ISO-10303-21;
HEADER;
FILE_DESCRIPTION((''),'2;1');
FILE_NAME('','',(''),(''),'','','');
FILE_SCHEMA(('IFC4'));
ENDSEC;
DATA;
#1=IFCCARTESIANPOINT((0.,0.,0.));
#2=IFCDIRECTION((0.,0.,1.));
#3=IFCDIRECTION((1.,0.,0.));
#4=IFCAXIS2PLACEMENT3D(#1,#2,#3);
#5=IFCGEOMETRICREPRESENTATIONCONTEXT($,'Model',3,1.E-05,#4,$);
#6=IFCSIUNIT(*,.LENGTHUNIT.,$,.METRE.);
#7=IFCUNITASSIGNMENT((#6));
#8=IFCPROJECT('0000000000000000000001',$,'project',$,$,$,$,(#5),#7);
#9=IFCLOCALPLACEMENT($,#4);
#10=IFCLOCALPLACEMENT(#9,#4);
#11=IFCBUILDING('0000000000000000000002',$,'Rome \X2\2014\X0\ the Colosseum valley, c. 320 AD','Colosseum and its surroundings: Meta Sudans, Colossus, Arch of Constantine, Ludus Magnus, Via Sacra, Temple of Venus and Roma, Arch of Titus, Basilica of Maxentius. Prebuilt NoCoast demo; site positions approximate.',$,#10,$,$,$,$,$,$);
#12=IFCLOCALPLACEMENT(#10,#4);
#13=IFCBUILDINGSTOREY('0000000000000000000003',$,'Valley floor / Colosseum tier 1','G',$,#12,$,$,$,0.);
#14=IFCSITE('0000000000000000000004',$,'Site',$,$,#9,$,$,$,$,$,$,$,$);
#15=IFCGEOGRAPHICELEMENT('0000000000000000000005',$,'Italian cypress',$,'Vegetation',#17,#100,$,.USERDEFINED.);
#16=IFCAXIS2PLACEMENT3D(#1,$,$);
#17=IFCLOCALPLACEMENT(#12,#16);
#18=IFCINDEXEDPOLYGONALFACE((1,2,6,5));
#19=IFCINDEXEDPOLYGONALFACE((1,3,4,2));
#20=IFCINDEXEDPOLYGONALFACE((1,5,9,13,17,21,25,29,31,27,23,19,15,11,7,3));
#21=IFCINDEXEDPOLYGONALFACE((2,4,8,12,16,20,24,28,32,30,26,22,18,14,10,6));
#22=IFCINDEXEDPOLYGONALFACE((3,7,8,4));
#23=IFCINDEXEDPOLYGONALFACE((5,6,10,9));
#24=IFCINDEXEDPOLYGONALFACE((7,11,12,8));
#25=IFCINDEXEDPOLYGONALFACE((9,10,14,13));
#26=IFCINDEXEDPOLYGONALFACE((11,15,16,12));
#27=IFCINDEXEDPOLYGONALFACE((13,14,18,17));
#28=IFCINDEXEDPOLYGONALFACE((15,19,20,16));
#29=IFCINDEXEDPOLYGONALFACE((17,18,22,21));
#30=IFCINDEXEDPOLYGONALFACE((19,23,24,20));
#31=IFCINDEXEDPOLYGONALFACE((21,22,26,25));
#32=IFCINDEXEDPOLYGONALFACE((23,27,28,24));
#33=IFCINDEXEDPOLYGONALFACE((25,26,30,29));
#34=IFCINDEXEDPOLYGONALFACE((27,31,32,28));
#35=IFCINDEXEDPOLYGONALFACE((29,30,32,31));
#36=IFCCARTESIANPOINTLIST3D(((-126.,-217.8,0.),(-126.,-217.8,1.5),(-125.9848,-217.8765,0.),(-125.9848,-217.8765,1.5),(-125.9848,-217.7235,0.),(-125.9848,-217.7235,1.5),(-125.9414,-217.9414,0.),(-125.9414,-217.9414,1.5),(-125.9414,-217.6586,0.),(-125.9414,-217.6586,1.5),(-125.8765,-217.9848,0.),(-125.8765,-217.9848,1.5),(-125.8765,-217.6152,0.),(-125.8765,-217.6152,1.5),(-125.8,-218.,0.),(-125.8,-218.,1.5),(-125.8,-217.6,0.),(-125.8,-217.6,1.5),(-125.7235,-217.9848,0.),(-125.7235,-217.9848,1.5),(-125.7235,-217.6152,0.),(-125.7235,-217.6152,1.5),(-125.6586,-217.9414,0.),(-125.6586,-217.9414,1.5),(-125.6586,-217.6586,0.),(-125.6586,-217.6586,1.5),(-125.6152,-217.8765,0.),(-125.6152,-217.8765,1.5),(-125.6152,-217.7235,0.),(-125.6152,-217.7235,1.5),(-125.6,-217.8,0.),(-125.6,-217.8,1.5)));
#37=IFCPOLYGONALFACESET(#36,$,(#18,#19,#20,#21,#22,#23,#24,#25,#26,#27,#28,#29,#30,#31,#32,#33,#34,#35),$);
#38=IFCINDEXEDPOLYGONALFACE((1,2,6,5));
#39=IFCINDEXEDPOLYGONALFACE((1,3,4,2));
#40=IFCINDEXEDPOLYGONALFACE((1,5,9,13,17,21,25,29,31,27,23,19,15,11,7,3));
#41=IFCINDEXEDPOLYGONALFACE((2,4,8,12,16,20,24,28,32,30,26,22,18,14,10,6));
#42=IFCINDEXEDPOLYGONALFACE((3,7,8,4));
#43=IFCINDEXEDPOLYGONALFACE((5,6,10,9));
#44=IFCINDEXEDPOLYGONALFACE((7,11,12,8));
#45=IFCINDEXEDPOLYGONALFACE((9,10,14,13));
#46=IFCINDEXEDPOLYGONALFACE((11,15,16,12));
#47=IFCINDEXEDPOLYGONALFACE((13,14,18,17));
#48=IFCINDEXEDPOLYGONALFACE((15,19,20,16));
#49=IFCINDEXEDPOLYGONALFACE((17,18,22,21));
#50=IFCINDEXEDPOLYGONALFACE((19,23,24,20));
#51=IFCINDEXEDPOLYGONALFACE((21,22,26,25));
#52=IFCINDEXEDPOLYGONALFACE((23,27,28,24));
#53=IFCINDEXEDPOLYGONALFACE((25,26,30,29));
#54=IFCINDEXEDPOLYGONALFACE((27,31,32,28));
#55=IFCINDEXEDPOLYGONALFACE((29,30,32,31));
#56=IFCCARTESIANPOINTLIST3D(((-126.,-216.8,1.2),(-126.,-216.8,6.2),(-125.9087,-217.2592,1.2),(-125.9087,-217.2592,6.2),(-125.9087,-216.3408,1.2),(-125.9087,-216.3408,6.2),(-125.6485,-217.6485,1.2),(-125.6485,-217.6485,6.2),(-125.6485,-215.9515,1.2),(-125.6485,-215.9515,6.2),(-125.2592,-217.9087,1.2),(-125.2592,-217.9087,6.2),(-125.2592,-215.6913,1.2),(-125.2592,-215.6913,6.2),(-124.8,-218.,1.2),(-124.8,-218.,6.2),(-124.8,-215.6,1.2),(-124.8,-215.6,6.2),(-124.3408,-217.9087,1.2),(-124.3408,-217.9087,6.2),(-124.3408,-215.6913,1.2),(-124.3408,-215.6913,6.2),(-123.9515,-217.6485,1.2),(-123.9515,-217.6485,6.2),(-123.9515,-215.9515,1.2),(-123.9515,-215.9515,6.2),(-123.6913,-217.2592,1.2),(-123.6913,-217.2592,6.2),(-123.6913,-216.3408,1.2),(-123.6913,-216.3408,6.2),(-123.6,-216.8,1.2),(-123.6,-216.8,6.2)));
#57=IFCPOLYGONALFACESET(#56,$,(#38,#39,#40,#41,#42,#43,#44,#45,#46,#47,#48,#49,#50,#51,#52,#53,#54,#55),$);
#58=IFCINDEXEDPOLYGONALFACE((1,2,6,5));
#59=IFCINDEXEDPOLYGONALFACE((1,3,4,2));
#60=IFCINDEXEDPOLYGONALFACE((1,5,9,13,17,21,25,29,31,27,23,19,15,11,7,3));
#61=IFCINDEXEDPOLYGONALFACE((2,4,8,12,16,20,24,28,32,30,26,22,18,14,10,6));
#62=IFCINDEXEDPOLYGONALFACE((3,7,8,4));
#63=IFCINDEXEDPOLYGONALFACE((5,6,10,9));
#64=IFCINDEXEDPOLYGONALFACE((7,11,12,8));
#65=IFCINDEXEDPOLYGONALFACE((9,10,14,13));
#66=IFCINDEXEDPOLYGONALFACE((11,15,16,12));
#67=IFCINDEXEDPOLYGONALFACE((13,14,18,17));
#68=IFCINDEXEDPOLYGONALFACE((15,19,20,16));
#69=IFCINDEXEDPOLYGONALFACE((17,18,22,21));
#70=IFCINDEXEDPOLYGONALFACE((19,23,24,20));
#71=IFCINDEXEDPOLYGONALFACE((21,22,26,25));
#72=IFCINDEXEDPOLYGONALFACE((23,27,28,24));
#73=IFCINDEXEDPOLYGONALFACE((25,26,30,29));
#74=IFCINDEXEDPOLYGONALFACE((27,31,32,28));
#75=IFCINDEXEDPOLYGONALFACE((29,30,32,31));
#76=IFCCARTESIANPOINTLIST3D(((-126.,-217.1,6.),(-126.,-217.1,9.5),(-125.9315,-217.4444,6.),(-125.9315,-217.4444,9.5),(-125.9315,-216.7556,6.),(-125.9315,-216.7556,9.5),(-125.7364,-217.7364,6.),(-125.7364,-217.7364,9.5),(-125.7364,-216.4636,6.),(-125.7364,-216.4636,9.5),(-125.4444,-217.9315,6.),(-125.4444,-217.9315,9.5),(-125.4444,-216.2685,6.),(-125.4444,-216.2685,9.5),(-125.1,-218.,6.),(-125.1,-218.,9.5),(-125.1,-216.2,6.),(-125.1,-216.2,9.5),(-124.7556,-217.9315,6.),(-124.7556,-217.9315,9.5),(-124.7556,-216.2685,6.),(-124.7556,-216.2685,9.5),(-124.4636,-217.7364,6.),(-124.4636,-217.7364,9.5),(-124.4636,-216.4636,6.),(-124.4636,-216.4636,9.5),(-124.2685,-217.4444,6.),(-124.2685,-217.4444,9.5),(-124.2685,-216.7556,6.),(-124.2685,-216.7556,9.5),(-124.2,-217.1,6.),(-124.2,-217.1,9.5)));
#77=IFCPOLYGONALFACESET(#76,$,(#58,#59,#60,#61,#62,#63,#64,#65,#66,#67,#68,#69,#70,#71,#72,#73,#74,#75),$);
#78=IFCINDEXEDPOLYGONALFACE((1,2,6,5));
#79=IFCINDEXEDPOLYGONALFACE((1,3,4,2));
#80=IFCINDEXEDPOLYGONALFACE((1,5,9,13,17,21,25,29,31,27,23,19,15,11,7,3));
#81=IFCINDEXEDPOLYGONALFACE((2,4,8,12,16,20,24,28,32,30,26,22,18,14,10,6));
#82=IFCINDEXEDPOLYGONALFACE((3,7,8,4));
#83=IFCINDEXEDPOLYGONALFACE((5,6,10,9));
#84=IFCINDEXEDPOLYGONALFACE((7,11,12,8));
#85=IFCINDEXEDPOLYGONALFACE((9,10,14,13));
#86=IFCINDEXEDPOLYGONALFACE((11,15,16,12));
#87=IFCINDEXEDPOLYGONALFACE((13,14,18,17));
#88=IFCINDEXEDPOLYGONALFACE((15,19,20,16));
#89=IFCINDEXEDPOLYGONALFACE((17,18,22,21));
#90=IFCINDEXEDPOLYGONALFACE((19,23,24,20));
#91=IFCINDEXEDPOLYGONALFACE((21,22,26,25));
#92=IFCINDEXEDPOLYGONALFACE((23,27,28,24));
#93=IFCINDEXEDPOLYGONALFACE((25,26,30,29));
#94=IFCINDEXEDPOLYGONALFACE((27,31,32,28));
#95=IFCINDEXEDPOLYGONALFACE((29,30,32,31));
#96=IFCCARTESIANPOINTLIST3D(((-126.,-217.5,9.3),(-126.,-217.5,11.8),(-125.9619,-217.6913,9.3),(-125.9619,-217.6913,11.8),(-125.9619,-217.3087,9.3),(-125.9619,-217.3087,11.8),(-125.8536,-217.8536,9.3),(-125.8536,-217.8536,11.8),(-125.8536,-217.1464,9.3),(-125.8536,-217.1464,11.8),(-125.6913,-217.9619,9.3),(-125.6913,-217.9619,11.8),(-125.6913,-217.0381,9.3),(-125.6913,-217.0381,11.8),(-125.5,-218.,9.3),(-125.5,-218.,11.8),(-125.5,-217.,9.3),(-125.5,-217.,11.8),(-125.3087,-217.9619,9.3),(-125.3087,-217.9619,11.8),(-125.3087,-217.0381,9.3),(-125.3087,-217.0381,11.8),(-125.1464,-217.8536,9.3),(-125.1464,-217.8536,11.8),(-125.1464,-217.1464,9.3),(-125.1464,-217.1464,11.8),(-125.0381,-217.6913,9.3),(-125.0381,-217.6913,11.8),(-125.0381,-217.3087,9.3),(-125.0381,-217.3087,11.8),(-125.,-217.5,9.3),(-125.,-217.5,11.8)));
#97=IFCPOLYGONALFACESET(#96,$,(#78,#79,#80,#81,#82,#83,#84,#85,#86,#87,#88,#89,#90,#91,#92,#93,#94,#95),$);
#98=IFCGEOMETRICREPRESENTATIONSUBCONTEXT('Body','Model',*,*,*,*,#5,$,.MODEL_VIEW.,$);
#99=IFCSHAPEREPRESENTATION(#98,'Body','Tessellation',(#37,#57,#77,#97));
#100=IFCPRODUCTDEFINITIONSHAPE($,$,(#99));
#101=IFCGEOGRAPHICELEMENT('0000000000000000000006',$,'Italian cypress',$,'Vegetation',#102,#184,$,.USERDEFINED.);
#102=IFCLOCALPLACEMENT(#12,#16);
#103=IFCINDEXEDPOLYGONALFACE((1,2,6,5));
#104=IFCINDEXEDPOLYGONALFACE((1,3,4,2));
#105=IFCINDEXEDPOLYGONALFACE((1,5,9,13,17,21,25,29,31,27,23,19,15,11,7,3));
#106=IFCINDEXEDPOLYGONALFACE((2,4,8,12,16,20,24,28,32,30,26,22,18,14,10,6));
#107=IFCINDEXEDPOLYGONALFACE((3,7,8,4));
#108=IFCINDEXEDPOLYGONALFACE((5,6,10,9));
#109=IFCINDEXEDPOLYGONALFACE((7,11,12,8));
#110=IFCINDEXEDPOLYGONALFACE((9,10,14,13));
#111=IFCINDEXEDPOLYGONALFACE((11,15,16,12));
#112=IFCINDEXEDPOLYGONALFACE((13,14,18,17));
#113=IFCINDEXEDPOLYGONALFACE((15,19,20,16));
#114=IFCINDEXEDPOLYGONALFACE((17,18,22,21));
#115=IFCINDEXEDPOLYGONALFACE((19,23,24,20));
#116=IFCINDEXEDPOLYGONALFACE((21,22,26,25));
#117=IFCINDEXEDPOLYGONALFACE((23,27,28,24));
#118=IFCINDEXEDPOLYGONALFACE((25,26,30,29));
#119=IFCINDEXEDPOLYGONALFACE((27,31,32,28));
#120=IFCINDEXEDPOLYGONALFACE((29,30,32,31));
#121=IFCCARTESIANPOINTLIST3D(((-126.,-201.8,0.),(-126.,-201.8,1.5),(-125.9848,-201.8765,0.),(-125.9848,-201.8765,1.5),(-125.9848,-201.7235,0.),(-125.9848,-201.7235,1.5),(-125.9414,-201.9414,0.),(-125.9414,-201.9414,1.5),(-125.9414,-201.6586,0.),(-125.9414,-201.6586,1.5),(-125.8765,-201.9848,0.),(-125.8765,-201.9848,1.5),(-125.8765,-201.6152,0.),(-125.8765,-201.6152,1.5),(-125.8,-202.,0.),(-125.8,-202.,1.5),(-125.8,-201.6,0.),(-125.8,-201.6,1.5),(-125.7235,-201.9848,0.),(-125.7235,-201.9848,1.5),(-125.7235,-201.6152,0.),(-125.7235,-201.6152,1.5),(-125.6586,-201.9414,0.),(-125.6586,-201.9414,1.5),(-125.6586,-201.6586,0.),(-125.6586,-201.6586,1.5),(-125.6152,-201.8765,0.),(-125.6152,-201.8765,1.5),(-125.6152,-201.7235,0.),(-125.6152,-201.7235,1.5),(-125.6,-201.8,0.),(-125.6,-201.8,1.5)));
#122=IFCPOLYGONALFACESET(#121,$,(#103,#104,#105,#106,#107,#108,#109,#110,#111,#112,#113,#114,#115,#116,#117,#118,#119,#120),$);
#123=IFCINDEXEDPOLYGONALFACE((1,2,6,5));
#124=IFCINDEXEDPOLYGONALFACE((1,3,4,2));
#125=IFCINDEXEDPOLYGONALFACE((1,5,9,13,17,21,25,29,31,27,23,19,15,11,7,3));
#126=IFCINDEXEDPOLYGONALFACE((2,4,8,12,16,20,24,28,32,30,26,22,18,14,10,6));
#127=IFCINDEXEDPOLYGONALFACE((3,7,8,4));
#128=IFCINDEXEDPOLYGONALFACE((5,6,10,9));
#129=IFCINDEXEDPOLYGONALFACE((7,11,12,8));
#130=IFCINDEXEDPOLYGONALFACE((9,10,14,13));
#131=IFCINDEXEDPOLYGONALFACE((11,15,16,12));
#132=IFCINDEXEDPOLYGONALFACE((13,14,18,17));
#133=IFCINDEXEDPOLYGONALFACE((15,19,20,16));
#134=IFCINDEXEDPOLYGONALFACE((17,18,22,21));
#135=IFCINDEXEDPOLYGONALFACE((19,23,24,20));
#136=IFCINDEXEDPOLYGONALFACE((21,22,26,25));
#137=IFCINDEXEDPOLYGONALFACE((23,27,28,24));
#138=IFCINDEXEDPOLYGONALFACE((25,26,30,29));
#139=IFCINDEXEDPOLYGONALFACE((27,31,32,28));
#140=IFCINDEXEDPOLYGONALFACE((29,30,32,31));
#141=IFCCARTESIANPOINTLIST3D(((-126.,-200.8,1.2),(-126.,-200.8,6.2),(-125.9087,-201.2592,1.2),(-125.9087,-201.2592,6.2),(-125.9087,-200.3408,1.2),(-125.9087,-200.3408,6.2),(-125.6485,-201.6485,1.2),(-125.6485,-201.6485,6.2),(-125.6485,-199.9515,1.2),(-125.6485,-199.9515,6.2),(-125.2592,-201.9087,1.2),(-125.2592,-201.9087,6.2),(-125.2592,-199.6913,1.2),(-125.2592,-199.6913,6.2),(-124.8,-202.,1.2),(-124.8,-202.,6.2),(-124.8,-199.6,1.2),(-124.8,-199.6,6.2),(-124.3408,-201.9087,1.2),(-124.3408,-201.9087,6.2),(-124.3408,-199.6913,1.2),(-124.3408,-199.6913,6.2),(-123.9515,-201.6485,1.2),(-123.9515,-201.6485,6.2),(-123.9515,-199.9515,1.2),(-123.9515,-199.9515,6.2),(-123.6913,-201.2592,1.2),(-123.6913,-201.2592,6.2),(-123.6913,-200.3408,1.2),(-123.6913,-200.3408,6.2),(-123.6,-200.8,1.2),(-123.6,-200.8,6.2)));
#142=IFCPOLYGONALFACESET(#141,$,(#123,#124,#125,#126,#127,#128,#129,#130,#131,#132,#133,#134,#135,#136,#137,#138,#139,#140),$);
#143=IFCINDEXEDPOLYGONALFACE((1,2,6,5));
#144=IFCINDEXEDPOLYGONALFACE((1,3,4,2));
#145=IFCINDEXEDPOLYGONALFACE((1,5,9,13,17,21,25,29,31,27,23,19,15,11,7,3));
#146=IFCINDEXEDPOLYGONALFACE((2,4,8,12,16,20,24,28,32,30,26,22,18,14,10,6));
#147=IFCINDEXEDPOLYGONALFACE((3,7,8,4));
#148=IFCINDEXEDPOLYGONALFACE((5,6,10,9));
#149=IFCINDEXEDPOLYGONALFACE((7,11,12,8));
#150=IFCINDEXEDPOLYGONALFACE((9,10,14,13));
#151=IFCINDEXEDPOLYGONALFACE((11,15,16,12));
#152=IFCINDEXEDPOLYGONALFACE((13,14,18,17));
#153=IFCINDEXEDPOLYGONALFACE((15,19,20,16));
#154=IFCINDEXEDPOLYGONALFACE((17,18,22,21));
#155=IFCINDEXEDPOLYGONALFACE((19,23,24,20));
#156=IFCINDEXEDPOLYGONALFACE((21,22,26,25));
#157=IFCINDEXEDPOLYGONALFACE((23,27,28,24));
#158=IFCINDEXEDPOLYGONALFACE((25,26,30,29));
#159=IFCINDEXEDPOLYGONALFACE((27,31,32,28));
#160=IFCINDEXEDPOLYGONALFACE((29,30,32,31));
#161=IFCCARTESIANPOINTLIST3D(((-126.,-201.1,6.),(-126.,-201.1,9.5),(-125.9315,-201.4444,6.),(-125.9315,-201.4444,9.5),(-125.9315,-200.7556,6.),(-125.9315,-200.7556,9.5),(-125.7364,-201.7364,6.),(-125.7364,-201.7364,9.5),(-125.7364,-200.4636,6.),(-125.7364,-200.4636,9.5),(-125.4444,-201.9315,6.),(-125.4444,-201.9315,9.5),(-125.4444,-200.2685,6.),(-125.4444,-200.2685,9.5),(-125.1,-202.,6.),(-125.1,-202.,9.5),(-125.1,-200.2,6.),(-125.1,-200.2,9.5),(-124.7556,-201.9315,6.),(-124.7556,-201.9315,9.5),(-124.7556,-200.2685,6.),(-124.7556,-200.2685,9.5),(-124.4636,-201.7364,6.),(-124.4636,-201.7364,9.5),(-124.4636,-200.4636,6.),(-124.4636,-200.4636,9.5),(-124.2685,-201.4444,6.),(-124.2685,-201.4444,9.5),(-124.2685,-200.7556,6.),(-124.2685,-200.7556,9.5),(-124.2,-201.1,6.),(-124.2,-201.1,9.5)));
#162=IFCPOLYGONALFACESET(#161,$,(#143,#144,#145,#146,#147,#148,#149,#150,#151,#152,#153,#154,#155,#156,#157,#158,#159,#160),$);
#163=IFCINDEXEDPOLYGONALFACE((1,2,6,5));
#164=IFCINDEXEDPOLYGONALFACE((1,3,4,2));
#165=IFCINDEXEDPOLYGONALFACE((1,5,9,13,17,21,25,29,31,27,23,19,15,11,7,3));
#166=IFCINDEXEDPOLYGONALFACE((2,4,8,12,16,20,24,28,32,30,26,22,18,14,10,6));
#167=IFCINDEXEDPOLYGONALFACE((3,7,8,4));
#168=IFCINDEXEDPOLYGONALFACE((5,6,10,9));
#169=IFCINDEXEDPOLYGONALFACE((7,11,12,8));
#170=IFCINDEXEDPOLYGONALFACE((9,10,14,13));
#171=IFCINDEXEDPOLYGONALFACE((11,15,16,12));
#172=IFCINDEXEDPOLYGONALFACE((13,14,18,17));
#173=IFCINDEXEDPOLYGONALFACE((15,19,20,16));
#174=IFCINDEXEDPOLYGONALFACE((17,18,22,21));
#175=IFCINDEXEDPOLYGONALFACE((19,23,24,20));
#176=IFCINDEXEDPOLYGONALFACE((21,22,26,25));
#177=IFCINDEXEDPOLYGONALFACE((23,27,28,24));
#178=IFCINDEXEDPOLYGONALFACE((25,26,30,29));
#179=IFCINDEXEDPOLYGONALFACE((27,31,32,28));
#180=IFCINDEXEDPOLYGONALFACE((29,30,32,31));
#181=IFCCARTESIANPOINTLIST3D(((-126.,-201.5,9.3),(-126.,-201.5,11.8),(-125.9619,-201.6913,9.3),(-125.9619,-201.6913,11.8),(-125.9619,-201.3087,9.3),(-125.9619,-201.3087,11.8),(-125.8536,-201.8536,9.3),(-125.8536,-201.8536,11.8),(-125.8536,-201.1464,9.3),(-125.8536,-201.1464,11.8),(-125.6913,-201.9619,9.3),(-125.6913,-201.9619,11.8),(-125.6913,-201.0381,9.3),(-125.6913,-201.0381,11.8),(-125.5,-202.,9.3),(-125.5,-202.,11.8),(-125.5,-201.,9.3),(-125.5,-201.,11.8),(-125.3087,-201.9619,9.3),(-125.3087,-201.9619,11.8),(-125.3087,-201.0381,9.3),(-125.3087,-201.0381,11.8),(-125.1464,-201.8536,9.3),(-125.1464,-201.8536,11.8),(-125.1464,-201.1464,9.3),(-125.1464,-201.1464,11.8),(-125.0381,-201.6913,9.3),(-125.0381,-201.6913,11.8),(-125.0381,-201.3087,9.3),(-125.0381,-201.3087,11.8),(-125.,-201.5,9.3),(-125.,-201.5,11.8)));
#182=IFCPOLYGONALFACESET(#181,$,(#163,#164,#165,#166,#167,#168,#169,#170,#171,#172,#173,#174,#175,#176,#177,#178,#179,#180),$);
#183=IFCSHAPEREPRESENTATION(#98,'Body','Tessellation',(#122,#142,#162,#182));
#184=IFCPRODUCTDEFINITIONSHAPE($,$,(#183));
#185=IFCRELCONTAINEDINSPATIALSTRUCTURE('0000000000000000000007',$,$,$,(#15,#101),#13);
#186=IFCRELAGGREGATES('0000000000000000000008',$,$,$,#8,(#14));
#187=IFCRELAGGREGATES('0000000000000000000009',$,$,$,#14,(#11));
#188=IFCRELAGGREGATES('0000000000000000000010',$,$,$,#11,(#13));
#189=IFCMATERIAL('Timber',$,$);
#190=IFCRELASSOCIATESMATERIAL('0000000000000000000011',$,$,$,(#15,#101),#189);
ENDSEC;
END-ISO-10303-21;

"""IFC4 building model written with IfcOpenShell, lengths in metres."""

from ifc_helpers import new_model, si_unit, frame, origin_with_axes, place, context, subcontext, project, spatial, polyline, outline, extrude, material, element, save


model = new_model("IFC4")

# Units and contexts
model_context = context("Model", 3, precision=1e-05, world=origin_with_axes())
body_context = subcontext(model_context, "Body", "Model", "MODEL_VIEW")
ifc_project = project(units=[si_unit("LENGTHUNIT", "METRE")], contexts=[model_context])

# Site, building, storey
site_placement = place(None, origin_with_axes())
site = spatial("IfcSite", under=ifc_project, at=site_placement, Name="Site")
building_placement = place(site_placement, origin_with_axes())
building = spatial("IfcBuilding", under=site, at=building_placement, Name="Rome — the Colosseum valley, c. 320 AD", Description="Colosseum and its surroundings: Meta Sudans, Colossus, Arch of Constantine, Ludus Magnus, Via Sacra, Temple of Venus and Roma, Arch of Titus, Basilica of Maxentius. Prebuilt NoCoast demo; site positions approximate.")
storey_placement = place(building_placement, origin_with_axes())
storey = spatial("IfcBuildingStorey", under=building, at=storey_placement, Name="Valley floor / Colosseum tier 1", Description="G", Elevation=0.0)

# Shared definitions
ifc_material_1 = material(Name="Timber")

# Geographic elements
geographic_element_1_placement = place(storey_placement, frame((-126.0, -218.0, 0.0), z_axis=(0.0, 0.0, 1.0), x_axis=(1.0, 0.0, 0.0)))
element("IfcGeographicElement", 1, at=geographic_element_1_placement, inside=storey, material=ifc_material_1, Name="Italian cypress", ObjectType="Vegetation", PredefinedType="USERDEFINED", context=body_context, shape_type="SweptSolid", body=[
    extrude(outline(polyline([(0.4, 0.2), (0.3848, 0.2765), (0.3414, 0.3414), (0.2765, 0.3848), (0.2, 0.4), (0.1235, 0.3848), (0.0586, 0.3414), (0.0152, 0.2765), (0.0, 0.2), (0.0152, 0.1235), (0.0586, 0.0586), (0.1235, 0.0152), (0.2, 0.0), (0.2765, 0.0152), (0.3414, 0.0586), (0.3848, 0.1235), (0.4, 0.2)])), origin_with_axes(), (0.0, 0.0, 1.0), 1.5),
    extrude(outline(polyline([(2.4, 1.2), (2.3087, 1.6592), (2.0485, 2.0485), (1.6592, 2.3087), (1.2, 2.4), (0.7408, 2.3087), (0.3515, 2.0485), (0.0913, 1.6592), (0.0, 1.2), (0.0913, 0.7408), (0.3515, 0.3515), (0.7408, 0.0913), (1.2, 0.0), (1.6592, 0.0913), (2.0485, 0.3515), (2.3087, 0.7408), (2.4, 1.2)])), frame((0.0, 0.0, 1.2), z_axis=(0.0, 0.0, 1.0), x_axis=(1.0, 0.0, 0.0)), (0.0, 0.0, 1.0), 5.0),
    extrude(outline(polyline([(1.8, 0.9), (1.7315, 1.2444), (1.5364, 1.5364), (1.2444, 1.7315), (0.9, 1.8), (0.5556, 1.7315), (0.2636, 1.5364), (0.0685, 1.2444), (0.0, 0.9), (0.0685, 0.5556), (0.2636, 0.2636), (0.5556, 0.0685), (0.9, 0.0), (1.2444, 0.0685), (1.5364, 0.2636), (1.7315, 0.5556), (1.8, 0.9)])), frame((0.0, 0.0, 6.0), z_axis=(0.0, 0.0, 1.0), x_axis=(1.0, 0.0, 0.0)), (0.0, 0.0, 1.0), 3.5),
    extrude(outline(polyline([(1.0, 0.5), (0.9619, 0.6913), (0.8536, 0.8536), (0.6913, 0.9619), (0.5, 1.0), (0.3087, 0.9619), (0.1464, 0.8536), (0.0381, 0.6913), (0.0, 0.5), (0.0381, 0.3087), (0.1464, 0.1464), (0.3087, 0.0381), (0.5, 0.0), (0.6913, 0.0381), (0.8536, 0.1464), (0.9619, 0.3087), (1.0, 0.5)])), frame((0.0, 0.0, 9.3), z_axis=(0.0, 0.0, 1.0), x_axis=(1.0, 0.0, 0.0)), (0.0, 0.0, 1.0), 2.5),
])
geographic_element_2_placement = place(storey_placement, frame((-126.0, -202.0, 0.0), z_axis=(0.0, 0.0, 1.0), x_axis=(1.0, 0.0, 0.0)))
element("IfcGeographicElement", 2, at=geographic_element_2_placement, inside=storey, material=ifc_material_1, Name="Italian cypress", ObjectType="Vegetation", PredefinedType="USERDEFINED", context=body_context, shape_type="SweptSolid", body=[
    extrude(outline(polyline([(0.4, 0.2), (0.3848, 0.2765), (0.3414, 0.3414), (0.2765, 0.3848), (0.2, 0.4), (0.1235, 0.3848), (0.0586, 0.3414), (0.0152, 0.2765), (0.0, 0.2), (0.0152, 0.1235), (0.0586, 0.0586), (0.1235, 0.0152), (0.2, 0.0), (0.2765, 0.0152), (0.3414, 0.0586), (0.3848, 0.1235), (0.4, 0.2)])), origin_with_axes(), (0.0, 0.0, 1.0), 1.5),
    extrude(outline(polyline([(2.4, 1.2), (2.3087, 1.6592), (2.0485, 2.0485), (1.6592, 2.3087), (1.2, 2.4), (0.7408, 2.3087), (0.3515, 2.0485), (0.0913, 1.6592), (0.0, 1.2), (0.0913, 0.7408), (0.3515, 0.3515), (0.7408, 0.0913), (1.2, 0.0), (1.6592, 0.0913), (2.0485, 0.3515), (2.3087, 0.7408), (2.4, 1.2)])), frame((0.0, 0.0, 1.2), z_axis=(0.0, 0.0, 1.0), x_axis=(1.0, 0.0, 0.0)), (0.0, 0.0, 1.0), 5.0),
    extrude(outline(polyline([(1.8, 0.9), (1.7315, 1.2444), (1.5364, 1.5364), (1.2444, 1.7315), (0.9, 1.8), (0.5556, 1.7315), (0.2636, 1.5364), (0.0685, 1.2444), (0.0, 0.9), (0.0685, 0.5556), (0.2636, 0.2636), (0.5556, 0.0685), (0.9, 0.0), (1.2444, 0.0685), (1.5364, 0.2636), (1.7315, 0.5556), (1.8, 0.9)])), frame((0.0, 0.0, 6.0), z_axis=(0.0, 0.0, 1.0), x_axis=(1.0, 0.0, 0.0)), (0.0, 0.0, 1.0), 3.5),
    extrude(outline(polyline([(1.0, 0.5), (0.9619, 0.6913), (0.8536, 0.8536), (0.6913, 0.9619), (0.5, 1.0), (0.3087, 0.9619), (0.1464, 0.8536), (0.0381, 0.6913), (0.0, 0.5), (0.0381, 0.3087), (0.1464, 0.1464), (0.3087, 0.0381), (0.5, 0.0), (0.6913, 0.0381), (0.8536, 0.1464), (0.9619, 0.3087), (1.0, 0.5)])), frame((0.0, 0.0, 9.3), z_axis=(0.0, 0.0, 1.0), x_axis=(1.0, 0.0, 0.0)), (0.0, 0.0, 1.0), 2.5),
])

save(model, "model.ifc")
